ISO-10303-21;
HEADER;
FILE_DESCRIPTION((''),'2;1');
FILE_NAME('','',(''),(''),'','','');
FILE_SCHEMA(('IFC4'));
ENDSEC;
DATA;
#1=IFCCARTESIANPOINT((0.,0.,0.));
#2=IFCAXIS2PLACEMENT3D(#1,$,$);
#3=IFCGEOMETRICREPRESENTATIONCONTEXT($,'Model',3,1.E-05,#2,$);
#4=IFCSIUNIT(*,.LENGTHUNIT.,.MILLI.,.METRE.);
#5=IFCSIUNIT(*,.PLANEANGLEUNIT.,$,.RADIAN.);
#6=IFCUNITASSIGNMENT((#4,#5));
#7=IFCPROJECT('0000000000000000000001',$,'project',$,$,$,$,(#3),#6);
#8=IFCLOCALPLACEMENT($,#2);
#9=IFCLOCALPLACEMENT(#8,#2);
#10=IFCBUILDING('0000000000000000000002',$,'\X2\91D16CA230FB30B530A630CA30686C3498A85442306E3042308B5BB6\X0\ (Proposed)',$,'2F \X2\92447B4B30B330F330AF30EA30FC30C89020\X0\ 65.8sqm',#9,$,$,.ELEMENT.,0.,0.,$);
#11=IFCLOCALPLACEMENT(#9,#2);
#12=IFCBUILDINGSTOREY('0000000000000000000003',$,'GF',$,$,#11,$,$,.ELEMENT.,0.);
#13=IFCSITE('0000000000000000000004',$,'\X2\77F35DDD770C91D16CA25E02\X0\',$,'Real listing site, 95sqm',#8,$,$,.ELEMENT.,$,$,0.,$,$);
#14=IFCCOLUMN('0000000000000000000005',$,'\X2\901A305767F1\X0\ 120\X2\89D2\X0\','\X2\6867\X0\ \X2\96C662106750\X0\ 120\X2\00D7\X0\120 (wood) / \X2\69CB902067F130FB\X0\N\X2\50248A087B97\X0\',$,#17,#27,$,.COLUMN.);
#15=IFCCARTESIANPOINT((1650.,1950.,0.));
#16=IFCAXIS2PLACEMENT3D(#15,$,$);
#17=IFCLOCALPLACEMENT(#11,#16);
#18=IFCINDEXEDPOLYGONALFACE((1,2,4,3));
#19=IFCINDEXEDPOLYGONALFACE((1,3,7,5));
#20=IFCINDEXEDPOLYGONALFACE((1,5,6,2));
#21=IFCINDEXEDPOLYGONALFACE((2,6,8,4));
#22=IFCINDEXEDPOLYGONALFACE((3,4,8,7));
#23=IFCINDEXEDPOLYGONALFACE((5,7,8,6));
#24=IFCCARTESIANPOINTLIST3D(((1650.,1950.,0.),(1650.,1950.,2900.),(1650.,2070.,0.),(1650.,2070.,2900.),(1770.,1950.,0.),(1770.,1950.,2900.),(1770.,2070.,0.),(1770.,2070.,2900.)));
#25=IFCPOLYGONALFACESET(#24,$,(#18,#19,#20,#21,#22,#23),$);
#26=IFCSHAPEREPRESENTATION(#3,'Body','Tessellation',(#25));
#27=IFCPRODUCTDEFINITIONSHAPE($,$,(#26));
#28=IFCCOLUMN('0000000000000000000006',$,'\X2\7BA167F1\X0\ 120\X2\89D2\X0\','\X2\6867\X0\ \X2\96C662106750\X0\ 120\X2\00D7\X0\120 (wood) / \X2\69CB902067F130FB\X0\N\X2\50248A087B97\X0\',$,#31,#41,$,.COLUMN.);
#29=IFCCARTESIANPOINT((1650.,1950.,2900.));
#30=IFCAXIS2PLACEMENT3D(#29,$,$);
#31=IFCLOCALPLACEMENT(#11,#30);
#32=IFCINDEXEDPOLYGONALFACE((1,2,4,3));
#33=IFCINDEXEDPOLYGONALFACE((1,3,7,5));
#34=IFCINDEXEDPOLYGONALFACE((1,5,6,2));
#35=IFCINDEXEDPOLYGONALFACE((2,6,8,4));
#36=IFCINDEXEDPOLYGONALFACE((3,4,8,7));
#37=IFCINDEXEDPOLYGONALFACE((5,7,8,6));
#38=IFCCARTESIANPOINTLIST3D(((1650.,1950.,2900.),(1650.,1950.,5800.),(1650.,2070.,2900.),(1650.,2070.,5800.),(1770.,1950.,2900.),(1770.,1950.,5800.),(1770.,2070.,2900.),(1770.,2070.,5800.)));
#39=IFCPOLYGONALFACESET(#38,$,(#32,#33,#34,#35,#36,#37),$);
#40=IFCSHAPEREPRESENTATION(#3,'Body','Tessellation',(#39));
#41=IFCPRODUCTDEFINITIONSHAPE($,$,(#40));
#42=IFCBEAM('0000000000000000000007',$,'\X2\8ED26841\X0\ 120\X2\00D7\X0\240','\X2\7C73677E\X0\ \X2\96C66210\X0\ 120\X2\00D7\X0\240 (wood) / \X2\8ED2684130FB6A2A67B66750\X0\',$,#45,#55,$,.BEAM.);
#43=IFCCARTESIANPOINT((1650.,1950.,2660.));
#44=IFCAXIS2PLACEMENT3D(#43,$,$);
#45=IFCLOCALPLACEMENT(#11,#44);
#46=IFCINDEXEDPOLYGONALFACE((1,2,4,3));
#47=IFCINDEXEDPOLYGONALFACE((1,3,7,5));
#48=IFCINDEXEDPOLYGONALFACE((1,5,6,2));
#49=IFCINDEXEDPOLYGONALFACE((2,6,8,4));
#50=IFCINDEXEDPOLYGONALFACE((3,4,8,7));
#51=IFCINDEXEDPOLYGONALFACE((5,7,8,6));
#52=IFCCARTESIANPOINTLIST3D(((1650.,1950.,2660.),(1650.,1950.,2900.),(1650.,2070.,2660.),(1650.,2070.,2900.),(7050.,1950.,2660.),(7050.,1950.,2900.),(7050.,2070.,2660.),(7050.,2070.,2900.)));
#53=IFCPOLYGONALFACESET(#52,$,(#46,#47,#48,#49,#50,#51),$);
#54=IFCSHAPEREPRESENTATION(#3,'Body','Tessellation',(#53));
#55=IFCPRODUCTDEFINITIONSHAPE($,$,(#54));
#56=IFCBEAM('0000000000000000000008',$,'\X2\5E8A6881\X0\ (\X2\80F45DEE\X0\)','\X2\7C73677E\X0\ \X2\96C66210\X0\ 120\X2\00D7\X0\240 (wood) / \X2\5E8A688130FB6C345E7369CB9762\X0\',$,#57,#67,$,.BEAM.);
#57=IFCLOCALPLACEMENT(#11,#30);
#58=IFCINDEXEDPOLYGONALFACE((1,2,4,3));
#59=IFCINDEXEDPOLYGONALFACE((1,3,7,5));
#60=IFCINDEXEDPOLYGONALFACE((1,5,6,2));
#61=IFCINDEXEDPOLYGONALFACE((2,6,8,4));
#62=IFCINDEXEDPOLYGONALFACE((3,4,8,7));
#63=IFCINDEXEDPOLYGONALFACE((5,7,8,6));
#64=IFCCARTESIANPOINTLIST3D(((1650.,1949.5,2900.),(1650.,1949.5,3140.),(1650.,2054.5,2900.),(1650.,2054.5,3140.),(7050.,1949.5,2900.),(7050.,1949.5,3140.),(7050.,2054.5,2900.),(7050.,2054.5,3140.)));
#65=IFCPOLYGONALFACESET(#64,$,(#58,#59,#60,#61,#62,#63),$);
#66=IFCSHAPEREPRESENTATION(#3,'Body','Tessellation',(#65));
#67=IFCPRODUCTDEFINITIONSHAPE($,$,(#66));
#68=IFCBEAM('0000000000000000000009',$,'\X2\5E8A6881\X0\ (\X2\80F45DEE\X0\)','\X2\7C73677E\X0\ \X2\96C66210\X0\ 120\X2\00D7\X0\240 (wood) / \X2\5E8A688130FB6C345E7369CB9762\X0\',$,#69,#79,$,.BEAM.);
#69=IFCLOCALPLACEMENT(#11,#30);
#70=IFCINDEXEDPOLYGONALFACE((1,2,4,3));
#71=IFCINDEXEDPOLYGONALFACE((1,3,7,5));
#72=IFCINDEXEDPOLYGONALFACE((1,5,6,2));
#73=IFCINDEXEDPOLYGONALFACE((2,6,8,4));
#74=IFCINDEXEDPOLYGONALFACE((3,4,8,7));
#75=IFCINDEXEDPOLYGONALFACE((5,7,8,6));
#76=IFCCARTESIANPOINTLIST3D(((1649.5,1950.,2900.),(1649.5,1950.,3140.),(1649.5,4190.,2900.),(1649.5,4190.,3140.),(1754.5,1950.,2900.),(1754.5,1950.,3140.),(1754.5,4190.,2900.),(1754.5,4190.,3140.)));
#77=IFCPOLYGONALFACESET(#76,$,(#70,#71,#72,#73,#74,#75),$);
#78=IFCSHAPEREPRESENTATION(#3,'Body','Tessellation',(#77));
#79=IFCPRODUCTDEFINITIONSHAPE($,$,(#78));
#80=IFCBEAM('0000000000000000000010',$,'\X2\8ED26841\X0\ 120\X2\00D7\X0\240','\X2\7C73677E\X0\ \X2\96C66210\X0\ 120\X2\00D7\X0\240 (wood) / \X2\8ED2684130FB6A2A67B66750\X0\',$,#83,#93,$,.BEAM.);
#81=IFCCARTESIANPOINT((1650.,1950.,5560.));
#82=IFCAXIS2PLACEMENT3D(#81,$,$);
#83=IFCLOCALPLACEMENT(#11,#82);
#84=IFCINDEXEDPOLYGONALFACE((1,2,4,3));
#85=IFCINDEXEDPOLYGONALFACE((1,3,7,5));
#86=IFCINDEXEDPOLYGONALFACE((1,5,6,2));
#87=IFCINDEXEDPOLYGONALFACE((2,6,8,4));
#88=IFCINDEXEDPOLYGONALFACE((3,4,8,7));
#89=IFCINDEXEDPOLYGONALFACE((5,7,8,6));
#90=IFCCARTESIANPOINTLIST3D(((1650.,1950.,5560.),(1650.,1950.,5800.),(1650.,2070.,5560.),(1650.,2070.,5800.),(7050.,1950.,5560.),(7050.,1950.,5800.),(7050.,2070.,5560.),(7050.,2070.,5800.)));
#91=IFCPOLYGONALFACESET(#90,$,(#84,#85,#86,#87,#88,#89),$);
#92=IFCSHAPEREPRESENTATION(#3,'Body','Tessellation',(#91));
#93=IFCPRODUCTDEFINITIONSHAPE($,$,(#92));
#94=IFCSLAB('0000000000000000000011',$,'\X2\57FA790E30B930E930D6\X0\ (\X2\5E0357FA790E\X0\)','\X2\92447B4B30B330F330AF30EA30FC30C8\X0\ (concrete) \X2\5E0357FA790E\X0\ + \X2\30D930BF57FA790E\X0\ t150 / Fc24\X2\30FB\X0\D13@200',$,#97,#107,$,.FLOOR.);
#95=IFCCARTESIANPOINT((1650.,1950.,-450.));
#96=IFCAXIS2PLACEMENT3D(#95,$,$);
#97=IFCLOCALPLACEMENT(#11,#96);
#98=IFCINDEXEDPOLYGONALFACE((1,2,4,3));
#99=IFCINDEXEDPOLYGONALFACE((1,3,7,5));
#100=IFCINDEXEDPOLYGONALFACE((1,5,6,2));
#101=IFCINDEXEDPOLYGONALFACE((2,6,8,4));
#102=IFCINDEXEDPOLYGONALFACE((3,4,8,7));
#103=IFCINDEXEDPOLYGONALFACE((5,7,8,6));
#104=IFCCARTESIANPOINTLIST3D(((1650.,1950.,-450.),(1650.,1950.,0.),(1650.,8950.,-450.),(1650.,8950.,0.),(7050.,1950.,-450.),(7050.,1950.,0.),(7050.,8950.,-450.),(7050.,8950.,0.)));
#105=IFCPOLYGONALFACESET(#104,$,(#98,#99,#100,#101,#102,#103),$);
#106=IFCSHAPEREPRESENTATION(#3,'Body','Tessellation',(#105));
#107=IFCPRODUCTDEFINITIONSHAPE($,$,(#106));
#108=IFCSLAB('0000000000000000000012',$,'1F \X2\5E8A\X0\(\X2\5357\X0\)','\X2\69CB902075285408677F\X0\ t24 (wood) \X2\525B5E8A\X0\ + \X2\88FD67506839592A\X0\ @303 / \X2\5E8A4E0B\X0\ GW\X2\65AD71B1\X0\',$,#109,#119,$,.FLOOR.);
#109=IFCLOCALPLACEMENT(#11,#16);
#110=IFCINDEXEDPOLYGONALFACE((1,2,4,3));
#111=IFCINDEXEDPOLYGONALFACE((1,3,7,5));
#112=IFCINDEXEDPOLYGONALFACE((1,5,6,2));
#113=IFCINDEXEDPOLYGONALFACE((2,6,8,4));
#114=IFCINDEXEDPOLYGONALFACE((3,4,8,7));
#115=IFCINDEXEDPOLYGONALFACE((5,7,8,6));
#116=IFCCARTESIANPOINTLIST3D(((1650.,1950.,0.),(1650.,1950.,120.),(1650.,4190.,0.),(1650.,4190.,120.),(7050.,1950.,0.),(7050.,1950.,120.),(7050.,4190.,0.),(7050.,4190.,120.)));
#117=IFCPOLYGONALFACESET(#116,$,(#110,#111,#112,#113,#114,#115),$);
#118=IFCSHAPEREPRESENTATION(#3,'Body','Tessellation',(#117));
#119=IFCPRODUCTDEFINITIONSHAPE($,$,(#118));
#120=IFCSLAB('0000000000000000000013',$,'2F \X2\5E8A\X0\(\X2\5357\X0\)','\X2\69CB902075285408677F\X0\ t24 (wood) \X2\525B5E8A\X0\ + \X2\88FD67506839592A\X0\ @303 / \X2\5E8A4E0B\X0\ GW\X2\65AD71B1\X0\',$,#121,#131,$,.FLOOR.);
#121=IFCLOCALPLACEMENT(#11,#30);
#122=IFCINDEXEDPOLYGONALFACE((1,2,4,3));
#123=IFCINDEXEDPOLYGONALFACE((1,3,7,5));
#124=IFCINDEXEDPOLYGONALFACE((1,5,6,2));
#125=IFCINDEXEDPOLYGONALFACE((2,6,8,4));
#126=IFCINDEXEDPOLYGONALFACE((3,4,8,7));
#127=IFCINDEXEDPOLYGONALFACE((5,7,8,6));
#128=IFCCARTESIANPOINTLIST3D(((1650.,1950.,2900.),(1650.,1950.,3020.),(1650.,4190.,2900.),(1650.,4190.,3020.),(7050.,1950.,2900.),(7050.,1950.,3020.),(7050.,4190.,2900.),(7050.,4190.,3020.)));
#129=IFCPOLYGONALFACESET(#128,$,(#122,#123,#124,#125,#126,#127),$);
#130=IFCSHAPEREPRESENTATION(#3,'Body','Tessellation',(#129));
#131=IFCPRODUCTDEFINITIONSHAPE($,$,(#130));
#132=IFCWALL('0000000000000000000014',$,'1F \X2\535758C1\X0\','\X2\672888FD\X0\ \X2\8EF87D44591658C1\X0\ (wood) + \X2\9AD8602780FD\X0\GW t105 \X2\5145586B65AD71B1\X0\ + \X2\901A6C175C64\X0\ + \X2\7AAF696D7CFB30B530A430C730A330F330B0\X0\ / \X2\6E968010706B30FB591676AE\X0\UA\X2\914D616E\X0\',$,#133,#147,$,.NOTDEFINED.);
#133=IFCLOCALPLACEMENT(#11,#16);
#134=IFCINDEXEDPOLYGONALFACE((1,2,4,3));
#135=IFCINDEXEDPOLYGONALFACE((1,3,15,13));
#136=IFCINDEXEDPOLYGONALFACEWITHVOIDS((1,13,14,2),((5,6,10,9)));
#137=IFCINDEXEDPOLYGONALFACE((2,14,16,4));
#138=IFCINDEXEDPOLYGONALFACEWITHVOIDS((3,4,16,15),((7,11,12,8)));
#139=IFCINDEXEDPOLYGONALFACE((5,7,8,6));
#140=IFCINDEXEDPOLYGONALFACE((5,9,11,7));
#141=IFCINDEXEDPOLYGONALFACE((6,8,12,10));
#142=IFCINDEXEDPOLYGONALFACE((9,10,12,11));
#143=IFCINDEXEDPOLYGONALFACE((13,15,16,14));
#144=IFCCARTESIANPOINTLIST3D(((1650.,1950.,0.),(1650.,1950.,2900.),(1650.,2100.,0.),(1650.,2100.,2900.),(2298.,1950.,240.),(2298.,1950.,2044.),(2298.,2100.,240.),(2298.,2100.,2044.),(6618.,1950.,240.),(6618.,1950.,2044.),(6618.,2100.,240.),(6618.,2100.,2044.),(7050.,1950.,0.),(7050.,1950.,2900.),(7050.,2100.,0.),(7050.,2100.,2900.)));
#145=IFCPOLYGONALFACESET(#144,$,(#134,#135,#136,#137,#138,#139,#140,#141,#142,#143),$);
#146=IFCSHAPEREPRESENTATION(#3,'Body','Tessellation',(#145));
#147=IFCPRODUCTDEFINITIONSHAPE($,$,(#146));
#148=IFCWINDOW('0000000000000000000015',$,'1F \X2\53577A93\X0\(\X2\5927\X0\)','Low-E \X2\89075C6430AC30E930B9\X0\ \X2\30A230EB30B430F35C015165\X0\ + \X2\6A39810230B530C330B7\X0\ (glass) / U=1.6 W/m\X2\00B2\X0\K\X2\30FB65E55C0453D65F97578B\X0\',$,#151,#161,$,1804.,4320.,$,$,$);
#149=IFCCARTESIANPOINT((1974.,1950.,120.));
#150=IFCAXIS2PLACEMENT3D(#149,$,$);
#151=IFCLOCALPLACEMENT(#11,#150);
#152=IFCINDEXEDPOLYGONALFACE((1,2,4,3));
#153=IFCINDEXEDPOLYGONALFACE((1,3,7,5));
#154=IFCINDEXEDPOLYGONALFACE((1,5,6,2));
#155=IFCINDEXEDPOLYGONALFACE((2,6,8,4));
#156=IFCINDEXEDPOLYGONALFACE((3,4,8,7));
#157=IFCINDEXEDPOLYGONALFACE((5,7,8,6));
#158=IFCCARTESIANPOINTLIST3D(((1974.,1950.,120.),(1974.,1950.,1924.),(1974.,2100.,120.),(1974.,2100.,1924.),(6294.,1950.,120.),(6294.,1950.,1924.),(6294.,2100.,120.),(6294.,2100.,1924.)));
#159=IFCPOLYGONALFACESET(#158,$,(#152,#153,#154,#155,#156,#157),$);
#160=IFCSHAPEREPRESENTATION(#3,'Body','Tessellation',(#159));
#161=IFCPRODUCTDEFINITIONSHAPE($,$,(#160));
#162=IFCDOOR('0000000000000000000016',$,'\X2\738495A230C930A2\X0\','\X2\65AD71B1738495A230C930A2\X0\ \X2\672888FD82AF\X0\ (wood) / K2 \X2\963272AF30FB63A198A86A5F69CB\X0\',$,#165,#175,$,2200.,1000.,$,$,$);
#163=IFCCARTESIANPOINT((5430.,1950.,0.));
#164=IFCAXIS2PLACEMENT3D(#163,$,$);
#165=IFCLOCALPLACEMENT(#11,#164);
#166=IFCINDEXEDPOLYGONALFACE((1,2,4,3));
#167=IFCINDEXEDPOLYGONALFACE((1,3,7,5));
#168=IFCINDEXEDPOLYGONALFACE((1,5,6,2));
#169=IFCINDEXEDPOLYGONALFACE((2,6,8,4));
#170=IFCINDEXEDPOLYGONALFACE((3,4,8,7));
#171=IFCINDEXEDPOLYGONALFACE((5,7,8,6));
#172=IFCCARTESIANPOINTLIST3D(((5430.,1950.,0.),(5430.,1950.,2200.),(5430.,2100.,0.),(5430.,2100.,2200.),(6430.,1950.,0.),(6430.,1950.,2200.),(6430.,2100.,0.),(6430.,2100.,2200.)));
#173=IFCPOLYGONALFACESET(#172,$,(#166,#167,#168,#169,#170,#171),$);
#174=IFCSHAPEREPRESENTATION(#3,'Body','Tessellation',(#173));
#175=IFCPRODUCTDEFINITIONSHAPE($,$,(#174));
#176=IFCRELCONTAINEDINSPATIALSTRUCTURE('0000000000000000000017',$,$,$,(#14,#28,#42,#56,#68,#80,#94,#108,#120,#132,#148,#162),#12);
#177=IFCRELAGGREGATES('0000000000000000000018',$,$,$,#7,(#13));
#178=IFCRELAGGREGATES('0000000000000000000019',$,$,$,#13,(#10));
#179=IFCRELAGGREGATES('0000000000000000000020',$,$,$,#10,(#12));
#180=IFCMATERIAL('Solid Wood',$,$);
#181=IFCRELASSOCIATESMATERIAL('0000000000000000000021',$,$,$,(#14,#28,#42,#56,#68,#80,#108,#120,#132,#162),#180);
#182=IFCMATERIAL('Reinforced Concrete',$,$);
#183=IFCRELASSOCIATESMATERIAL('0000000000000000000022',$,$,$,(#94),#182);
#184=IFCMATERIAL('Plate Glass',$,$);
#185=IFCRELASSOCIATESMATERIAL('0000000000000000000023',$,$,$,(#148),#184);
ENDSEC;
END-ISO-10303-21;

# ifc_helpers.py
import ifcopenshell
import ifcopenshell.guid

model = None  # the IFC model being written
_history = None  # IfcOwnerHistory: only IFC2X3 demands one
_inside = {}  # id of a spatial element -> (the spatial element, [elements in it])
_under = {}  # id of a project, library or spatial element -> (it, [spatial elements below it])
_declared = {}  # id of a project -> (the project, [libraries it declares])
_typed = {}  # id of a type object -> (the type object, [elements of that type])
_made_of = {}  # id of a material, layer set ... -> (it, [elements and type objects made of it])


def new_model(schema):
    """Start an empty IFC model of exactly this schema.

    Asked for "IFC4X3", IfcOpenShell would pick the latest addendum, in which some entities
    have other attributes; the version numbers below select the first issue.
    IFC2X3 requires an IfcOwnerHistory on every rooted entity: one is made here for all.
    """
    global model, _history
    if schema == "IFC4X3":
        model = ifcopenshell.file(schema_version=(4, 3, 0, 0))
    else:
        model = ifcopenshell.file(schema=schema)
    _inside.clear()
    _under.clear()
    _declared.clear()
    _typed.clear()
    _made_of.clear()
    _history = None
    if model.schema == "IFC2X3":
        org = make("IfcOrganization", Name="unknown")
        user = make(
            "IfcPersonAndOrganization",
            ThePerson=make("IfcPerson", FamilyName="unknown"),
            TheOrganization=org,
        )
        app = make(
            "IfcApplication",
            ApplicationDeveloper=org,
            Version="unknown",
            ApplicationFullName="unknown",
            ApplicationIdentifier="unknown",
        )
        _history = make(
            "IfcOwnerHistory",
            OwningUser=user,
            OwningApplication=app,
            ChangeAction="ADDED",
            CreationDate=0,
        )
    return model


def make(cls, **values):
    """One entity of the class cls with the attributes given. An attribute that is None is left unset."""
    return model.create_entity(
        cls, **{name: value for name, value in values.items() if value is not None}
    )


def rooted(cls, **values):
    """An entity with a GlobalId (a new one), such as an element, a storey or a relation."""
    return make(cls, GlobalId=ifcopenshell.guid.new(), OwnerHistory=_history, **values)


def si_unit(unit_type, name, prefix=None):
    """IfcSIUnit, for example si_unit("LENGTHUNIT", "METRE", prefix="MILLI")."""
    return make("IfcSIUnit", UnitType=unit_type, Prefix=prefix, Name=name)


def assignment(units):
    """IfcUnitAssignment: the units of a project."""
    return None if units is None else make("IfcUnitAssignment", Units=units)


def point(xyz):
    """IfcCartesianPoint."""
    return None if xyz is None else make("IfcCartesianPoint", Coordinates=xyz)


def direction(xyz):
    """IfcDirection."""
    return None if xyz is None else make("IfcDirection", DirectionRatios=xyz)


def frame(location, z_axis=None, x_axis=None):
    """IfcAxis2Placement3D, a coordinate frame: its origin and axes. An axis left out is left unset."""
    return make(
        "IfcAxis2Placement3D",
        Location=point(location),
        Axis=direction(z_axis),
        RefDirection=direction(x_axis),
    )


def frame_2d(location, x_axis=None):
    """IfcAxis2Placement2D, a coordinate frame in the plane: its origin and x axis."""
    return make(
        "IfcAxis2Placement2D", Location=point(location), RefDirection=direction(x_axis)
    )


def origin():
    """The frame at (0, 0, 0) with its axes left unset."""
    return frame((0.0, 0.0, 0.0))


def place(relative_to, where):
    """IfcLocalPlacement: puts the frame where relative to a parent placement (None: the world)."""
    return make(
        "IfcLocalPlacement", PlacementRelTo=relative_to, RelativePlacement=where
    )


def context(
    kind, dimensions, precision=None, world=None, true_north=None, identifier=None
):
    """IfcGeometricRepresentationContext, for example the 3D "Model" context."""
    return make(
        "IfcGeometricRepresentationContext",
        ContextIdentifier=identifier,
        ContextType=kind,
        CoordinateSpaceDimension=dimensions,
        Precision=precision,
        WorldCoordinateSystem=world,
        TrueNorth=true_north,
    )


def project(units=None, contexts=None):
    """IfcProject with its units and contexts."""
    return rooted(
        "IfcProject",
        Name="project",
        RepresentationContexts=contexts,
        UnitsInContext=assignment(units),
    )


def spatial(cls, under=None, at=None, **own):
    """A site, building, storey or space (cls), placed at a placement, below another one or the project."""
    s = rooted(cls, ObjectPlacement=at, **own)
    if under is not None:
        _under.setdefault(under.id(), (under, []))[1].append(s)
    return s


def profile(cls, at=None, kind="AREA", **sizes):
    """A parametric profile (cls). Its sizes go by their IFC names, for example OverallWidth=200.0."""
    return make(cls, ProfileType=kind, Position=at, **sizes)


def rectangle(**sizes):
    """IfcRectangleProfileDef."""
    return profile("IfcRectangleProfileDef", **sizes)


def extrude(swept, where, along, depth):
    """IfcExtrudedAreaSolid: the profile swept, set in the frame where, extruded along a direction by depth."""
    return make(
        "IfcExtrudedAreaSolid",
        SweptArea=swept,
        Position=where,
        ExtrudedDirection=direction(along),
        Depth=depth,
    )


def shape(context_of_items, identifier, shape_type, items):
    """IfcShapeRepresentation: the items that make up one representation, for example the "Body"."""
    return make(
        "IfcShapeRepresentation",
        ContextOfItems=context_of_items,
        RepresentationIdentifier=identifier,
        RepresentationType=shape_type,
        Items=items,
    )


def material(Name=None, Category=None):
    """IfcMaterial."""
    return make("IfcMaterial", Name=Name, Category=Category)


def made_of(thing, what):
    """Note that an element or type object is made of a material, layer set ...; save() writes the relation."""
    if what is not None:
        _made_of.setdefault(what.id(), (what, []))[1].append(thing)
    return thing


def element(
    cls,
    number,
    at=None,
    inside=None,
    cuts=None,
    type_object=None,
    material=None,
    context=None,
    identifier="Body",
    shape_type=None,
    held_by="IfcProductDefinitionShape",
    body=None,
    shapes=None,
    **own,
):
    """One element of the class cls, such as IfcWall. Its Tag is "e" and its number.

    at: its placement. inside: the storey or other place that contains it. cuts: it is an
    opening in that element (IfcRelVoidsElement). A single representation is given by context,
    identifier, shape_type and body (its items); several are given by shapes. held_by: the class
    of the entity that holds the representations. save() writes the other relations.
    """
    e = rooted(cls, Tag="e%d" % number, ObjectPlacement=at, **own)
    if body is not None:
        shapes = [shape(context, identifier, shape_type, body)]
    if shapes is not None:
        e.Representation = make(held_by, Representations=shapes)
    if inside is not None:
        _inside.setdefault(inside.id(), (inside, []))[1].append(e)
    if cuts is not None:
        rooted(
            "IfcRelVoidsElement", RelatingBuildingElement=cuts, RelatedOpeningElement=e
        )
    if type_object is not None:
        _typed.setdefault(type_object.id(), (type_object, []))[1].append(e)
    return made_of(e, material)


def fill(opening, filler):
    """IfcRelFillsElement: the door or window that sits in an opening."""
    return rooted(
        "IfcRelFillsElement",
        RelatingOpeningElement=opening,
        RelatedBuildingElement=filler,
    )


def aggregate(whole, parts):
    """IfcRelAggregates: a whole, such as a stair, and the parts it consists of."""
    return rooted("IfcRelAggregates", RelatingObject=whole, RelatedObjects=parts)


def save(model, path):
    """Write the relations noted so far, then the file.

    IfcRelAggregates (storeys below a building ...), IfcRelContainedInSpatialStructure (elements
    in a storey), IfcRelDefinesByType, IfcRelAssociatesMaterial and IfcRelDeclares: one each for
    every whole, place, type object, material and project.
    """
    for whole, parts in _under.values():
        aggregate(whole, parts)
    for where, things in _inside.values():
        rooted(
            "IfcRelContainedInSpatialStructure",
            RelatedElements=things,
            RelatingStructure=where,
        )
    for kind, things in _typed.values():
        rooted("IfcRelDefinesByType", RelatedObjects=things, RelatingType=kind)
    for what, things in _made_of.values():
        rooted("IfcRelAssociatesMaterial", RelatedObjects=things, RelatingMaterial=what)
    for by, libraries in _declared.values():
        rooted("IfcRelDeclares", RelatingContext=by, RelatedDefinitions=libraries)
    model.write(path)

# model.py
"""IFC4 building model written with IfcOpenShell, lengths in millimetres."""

from ifc_helpers import new_model, si_unit, frame, frame_2d, origin, place, context, project, spatial, rectangle, extrude, material, element, fill, save


model = new_model("IFC4")

# Units and contexts
model_context = context("Model", 3, precision=1e-05, world=origin())
ifc_project = project(units=[si_unit("LENGTHUNIT", "METRE", prefix="MILLI"), si_unit("PLANEANGLEUNIT", "RADIAN")], contexts=[model_context])

# Site, building, storey
site_placement = place(None, origin())
site = spatial("IfcSite", under=ifc_project, at=site_placement, Name="石川県金沢市", ObjectType="Real listing site, 95sqm", CompositionType="ELEMENT", RefElevation=0.0)
building_placement = place(site_placement, origin())
building = spatial("IfcBuilding", under=site, at=building_placement, Name="金沢・サウナと水風呂のある家 (Proposed)", ObjectType="2F 鉄筋コンクリート造 65.8sqm", CompositionType="ELEMENT", ElevationOfRefHeight=0.0, ElevationOfTerrain=0.0)
storey_placement = place(building_placement, origin())
storey = spatial("IfcBuildingStorey", under=building, at=storey_placement, Name="GF", CompositionType="ELEMENT", Elevation=0.0)

# Columns
ifc_material_1 = material(Name="Solid Wood")
column_1_placement = place(storey_placement, frame((1650.0, 1950.0, 0.0)))
element("IfcColumn", 1, at=column_1_placement, inside=storey, material=ifc_material_1, Name="通し柱 120角", Description="桧 集成材 120×120 (wood) / 構造柱・N値計算", PredefinedType="COLUMN", context=model_context, shape_type="SweptSolid", body=[
    extrude(rectangle(XDim=120.0, YDim=120.0, at=frame_2d((60.0, 60.0))), frame((1650.0, 1950.0, 0.0)), (0.0, 0.0, 1.0), 2900.0),
])
column_2_placement = place(storey_placement, frame((1650.0, 1950.0, 2900.0)))
element("IfcColumn", 2, at=column_2_placement, inside=storey, material=ifc_material_1, Name="管柱 120角", Description="桧 集成材 120×120 (wood) / 構造柱・N値計算", PredefinedType="COLUMN", context=model_context, shape_type="SweptSolid", body=[
    extrude(rectangle(XDim=120.0, YDim=120.0, at=frame_2d((60.0, 60.0))), frame((1650.0, 1950.0, 2900.0)), (0.0, 0.0, 1.0), 2900.0),
])

# Beams
beam_1_placement = place(storey_placement, frame((1650.0, 1950.0, 2660.0)))
element("IfcBeam", 3, at=beam_1_placement, inside=storey, material=ifc_material_1, Name="軒桁 120×240", Description="米松 集成 120×240 (wood) / 軒桁・横架材", PredefinedType="BEAM", context=model_context, shape_type="SweptSolid", body=[
    extrude(rectangle(XDim=5400.0, YDim=120.0, at=frame_2d((2700.0, 60.0))), frame((1650.0, 1950.0, 2660.0)), (0.0, 0.0, 1.0), 240.0),
])
beam_2_placement = place(storey_placement, frame((1650.0, 1950.0, 2900.0)))
element("IfcBeam", 4, at=beam_2_placement, inside=storey, material=ifc_material_1, Name="床梁 (胴差)", Description="米松 集成 120×240 (wood) / 床梁・水平構面", PredefinedType="BEAM", context=model_context, shape_type="SweptSolid", body=[
    extrude(rectangle(XDim=5400.0, YDim=105.0, at=frame_2d((2700.0, 52.0))), frame((1650.0, 1950.0, 2900.0)), (0.0, 0.0, 1.0), 240.0),
])
beam_3_placement = place(storey_placement, frame((1650.0, 1950.0, 2900.0)))
element("IfcBeam", 5, at=beam_3_placement, inside=storey, material=ifc_material_1, Name="床梁 (胴差)", Description="米松 集成 120×240 (wood) / 床梁・水平構面", PredefinedType="BEAM", context=model_context, shape_type="SweptSolid", body=[
    extrude(rectangle(XDim=105.0, YDim=2240.0, at=frame_2d((52.0, 1120.0))), frame((1650.0, 1950.0, 2900.0)), (0.0, 0.0, 1.0), 240.0),
])
beam_4_placement = place(storey_placement, frame((1650.0, 1950.0, 5560.0)))
element("IfcBeam", 6, at=beam_4_placement, inside=storey, material=ifc_material_1, Name="軒桁 120×240", Description="米松 集成 120×240 (wood) / 軒桁・横架材", PredefinedType="BEAM", context=model_context, shape_type="SweptSolid", body=[
    extrude(rectangle(XDim=5400.0, YDim=120.0, at=frame_2d((2700.0, 60.0))), frame((1650.0, 1950.0, 5560.0)), (0.0, 0.0, 1.0), 240.0),
])

# Slabs
ifc_material_2 = material(Name="Reinforced Concrete")
slab_1_placement = place(storey_placement, frame((1650.0, 1950.0, -450.0)))
element("IfcSlab", 7, at=slab_1_placement, inside=storey, material=ifc_material_2, Name="基礎スラブ (布基礎)", Description="鉄筋コンクリート (concrete) 布基礎 + ベタ基礎 t150 / Fc24・D13@200", PredefinedType="FLOOR", context=model_context, shape_type="SweptSolid", body=[
    extrude(rectangle(XDim=5400.0, YDim=7000.0, at=frame_2d((2700.0, 3500.0))), frame((1650.0, 1950.0, -450.0)), (0.0, 0.0, 1.0), 450.0),
])
slab_2_placement = place(storey_placement, frame((1650.0, 1950.0, 0.0)))
element("IfcSlab", 8, at=slab_2_placement, inside=storey, material=ifc_material_1, Name="1F 床(南)", Description="構造用合板 t24 (wood) 剛床 + 製材根太 @303 / 床下 GW断熱", PredefinedType="FLOOR", context=model_context, shape_type="SweptSolid", body=[
    extrude(rectangle(XDim=5400.0, YDim=2240.0, at=frame_2d((2700.0, 1120.0))), frame((1650.0, 1950.0, 0.0)), (0.0, 0.0, 1.0), 120.0),
])
slab_3_placement = place(storey_placement, frame((1650.0, 1950.0, 2900.0)))
element("IfcSlab", 9, at=slab_3_placement, inside=storey, material=ifc_material_1, Name="2F 床(南)", Description="構造用合板 t24 (wood) 剛床 + 製材根太 @303 / 床下 GW断熱", PredefinedType="FLOOR", context=model_context, shape_type="SweptSolid", body=[
    extrude(rectangle(XDim=5400.0, YDim=2240.0, at=frame_2d((2700.0, 1120.0))), frame((1650.0, 1950.0, 2900.0)), (0.0, 0.0, 1.0), 120.0),
])

# Wall, openings, window, door
wall_1_placement = place(storey_placement, frame((1650.0, 1950.0, 0.0)))
wall_1 = element("IfcWall", 10, at=wall_1_placement, inside=storey, material=ifc_material_1, Name="1F 南壁", Description="木製 軸組外壁 (wood) + 高性能GW t105 充填断熱 + 通気層 + 窯業系サイディング / 準耐火・外皮UA配慮", PredefinedType="NOTDEFINED", context=model_context, shape_type="SweptSolid", body=[
    extrude(rectangle(XDim=5400.0, YDim=150.0, at=frame_2d((2700.0, 75.0))), frame((1650.0, 1950.0, 0.0)), (0.0, 0.0, 1.0), 2900.0),
])
opening_1_placement = place(storey_placement, frame((1974.0, 1950.0, 120.0)))
opening_1 = element("IfcOpeningElement", 11, at=opening_1_placement, cuts=wall_1, PredefinedType="NOTDEFINED", context=model_context, shape_type="SweptSolid", body=[
    extrude(rectangle(XDim=4320.0, YDim=150.0, at=frame_2d((2160.0, 75.0))), frame((1974.0, 1950.0, 120.0)), (0.0, 0.0, 1.0), 1804.0),
])
opening_2_placement = place(storey_placement, frame((5430.0, 1950.0, 0.0)))
opening_2 = element("IfcOpeningElement", 12, at=opening_2_placement, cuts=wall_1, PredefinedType="NOTDEFINED", context=model_context, shape_type="SweptSolid", body=[
    extrude(rectangle(XDim=1000.0, YDim=150.0, at=frame_2d((500.0, 75.0))), frame((5430.0, 1950.0, 0.0)), (0.0, 0.0, 1.0), 2200.0),
])
ifc_material_3 = material(Name="Plate Glass")
window_1_placement = place(storey_placement, frame((1974.0, 1950.0, 120.0)))
window_1 = element("IfcWindow", 13, at=window_1_placement, inside=storey, material=ifc_material_3, Name="1F 南窓(大)", Description="Low-E 複層ガラス アルゴン封入 + 樹脂サッシ (glass) / U=1.6 W/m²K・日射取得型", OverallHeight=1804.0, OverallWidth=4320.0, context=model_context, shape_type="SweptSolid", body=[
    extrude(rectangle(XDim=4320.0, YDim=150.0, at=frame_2d((2160.0, 75.0))), frame((1974.0, 1950.0, 120.0)), (0.0, 0.0, 1.0), 1804.0),
])
fill(opening_1, window_1)
door_placement = place(storey_placement, frame((5430.0, 1950.0, 0.0)))
door = element("IfcDoor", 14, at=door_placement, inside=storey, material=ifc_material_1, Name="玄関ドア", Description="断熱玄関ドア 木製芯 (wood) / K2 防犯・採風機構", OverallHeight=2200.0, OverallWidth=1000.0, context=model_context, shape_type="SweptSolid", body=[
    extrude(rectangle(XDim=1000.0, YDim=150.0, at=frame_2d((500.0, 75.0))), frame((5430.0, 1950.0, 0.0)), (0.0, 0.0, 1.0), 2200.0),
])
fill(opening_2, door)

save(model, "model.ifc")
